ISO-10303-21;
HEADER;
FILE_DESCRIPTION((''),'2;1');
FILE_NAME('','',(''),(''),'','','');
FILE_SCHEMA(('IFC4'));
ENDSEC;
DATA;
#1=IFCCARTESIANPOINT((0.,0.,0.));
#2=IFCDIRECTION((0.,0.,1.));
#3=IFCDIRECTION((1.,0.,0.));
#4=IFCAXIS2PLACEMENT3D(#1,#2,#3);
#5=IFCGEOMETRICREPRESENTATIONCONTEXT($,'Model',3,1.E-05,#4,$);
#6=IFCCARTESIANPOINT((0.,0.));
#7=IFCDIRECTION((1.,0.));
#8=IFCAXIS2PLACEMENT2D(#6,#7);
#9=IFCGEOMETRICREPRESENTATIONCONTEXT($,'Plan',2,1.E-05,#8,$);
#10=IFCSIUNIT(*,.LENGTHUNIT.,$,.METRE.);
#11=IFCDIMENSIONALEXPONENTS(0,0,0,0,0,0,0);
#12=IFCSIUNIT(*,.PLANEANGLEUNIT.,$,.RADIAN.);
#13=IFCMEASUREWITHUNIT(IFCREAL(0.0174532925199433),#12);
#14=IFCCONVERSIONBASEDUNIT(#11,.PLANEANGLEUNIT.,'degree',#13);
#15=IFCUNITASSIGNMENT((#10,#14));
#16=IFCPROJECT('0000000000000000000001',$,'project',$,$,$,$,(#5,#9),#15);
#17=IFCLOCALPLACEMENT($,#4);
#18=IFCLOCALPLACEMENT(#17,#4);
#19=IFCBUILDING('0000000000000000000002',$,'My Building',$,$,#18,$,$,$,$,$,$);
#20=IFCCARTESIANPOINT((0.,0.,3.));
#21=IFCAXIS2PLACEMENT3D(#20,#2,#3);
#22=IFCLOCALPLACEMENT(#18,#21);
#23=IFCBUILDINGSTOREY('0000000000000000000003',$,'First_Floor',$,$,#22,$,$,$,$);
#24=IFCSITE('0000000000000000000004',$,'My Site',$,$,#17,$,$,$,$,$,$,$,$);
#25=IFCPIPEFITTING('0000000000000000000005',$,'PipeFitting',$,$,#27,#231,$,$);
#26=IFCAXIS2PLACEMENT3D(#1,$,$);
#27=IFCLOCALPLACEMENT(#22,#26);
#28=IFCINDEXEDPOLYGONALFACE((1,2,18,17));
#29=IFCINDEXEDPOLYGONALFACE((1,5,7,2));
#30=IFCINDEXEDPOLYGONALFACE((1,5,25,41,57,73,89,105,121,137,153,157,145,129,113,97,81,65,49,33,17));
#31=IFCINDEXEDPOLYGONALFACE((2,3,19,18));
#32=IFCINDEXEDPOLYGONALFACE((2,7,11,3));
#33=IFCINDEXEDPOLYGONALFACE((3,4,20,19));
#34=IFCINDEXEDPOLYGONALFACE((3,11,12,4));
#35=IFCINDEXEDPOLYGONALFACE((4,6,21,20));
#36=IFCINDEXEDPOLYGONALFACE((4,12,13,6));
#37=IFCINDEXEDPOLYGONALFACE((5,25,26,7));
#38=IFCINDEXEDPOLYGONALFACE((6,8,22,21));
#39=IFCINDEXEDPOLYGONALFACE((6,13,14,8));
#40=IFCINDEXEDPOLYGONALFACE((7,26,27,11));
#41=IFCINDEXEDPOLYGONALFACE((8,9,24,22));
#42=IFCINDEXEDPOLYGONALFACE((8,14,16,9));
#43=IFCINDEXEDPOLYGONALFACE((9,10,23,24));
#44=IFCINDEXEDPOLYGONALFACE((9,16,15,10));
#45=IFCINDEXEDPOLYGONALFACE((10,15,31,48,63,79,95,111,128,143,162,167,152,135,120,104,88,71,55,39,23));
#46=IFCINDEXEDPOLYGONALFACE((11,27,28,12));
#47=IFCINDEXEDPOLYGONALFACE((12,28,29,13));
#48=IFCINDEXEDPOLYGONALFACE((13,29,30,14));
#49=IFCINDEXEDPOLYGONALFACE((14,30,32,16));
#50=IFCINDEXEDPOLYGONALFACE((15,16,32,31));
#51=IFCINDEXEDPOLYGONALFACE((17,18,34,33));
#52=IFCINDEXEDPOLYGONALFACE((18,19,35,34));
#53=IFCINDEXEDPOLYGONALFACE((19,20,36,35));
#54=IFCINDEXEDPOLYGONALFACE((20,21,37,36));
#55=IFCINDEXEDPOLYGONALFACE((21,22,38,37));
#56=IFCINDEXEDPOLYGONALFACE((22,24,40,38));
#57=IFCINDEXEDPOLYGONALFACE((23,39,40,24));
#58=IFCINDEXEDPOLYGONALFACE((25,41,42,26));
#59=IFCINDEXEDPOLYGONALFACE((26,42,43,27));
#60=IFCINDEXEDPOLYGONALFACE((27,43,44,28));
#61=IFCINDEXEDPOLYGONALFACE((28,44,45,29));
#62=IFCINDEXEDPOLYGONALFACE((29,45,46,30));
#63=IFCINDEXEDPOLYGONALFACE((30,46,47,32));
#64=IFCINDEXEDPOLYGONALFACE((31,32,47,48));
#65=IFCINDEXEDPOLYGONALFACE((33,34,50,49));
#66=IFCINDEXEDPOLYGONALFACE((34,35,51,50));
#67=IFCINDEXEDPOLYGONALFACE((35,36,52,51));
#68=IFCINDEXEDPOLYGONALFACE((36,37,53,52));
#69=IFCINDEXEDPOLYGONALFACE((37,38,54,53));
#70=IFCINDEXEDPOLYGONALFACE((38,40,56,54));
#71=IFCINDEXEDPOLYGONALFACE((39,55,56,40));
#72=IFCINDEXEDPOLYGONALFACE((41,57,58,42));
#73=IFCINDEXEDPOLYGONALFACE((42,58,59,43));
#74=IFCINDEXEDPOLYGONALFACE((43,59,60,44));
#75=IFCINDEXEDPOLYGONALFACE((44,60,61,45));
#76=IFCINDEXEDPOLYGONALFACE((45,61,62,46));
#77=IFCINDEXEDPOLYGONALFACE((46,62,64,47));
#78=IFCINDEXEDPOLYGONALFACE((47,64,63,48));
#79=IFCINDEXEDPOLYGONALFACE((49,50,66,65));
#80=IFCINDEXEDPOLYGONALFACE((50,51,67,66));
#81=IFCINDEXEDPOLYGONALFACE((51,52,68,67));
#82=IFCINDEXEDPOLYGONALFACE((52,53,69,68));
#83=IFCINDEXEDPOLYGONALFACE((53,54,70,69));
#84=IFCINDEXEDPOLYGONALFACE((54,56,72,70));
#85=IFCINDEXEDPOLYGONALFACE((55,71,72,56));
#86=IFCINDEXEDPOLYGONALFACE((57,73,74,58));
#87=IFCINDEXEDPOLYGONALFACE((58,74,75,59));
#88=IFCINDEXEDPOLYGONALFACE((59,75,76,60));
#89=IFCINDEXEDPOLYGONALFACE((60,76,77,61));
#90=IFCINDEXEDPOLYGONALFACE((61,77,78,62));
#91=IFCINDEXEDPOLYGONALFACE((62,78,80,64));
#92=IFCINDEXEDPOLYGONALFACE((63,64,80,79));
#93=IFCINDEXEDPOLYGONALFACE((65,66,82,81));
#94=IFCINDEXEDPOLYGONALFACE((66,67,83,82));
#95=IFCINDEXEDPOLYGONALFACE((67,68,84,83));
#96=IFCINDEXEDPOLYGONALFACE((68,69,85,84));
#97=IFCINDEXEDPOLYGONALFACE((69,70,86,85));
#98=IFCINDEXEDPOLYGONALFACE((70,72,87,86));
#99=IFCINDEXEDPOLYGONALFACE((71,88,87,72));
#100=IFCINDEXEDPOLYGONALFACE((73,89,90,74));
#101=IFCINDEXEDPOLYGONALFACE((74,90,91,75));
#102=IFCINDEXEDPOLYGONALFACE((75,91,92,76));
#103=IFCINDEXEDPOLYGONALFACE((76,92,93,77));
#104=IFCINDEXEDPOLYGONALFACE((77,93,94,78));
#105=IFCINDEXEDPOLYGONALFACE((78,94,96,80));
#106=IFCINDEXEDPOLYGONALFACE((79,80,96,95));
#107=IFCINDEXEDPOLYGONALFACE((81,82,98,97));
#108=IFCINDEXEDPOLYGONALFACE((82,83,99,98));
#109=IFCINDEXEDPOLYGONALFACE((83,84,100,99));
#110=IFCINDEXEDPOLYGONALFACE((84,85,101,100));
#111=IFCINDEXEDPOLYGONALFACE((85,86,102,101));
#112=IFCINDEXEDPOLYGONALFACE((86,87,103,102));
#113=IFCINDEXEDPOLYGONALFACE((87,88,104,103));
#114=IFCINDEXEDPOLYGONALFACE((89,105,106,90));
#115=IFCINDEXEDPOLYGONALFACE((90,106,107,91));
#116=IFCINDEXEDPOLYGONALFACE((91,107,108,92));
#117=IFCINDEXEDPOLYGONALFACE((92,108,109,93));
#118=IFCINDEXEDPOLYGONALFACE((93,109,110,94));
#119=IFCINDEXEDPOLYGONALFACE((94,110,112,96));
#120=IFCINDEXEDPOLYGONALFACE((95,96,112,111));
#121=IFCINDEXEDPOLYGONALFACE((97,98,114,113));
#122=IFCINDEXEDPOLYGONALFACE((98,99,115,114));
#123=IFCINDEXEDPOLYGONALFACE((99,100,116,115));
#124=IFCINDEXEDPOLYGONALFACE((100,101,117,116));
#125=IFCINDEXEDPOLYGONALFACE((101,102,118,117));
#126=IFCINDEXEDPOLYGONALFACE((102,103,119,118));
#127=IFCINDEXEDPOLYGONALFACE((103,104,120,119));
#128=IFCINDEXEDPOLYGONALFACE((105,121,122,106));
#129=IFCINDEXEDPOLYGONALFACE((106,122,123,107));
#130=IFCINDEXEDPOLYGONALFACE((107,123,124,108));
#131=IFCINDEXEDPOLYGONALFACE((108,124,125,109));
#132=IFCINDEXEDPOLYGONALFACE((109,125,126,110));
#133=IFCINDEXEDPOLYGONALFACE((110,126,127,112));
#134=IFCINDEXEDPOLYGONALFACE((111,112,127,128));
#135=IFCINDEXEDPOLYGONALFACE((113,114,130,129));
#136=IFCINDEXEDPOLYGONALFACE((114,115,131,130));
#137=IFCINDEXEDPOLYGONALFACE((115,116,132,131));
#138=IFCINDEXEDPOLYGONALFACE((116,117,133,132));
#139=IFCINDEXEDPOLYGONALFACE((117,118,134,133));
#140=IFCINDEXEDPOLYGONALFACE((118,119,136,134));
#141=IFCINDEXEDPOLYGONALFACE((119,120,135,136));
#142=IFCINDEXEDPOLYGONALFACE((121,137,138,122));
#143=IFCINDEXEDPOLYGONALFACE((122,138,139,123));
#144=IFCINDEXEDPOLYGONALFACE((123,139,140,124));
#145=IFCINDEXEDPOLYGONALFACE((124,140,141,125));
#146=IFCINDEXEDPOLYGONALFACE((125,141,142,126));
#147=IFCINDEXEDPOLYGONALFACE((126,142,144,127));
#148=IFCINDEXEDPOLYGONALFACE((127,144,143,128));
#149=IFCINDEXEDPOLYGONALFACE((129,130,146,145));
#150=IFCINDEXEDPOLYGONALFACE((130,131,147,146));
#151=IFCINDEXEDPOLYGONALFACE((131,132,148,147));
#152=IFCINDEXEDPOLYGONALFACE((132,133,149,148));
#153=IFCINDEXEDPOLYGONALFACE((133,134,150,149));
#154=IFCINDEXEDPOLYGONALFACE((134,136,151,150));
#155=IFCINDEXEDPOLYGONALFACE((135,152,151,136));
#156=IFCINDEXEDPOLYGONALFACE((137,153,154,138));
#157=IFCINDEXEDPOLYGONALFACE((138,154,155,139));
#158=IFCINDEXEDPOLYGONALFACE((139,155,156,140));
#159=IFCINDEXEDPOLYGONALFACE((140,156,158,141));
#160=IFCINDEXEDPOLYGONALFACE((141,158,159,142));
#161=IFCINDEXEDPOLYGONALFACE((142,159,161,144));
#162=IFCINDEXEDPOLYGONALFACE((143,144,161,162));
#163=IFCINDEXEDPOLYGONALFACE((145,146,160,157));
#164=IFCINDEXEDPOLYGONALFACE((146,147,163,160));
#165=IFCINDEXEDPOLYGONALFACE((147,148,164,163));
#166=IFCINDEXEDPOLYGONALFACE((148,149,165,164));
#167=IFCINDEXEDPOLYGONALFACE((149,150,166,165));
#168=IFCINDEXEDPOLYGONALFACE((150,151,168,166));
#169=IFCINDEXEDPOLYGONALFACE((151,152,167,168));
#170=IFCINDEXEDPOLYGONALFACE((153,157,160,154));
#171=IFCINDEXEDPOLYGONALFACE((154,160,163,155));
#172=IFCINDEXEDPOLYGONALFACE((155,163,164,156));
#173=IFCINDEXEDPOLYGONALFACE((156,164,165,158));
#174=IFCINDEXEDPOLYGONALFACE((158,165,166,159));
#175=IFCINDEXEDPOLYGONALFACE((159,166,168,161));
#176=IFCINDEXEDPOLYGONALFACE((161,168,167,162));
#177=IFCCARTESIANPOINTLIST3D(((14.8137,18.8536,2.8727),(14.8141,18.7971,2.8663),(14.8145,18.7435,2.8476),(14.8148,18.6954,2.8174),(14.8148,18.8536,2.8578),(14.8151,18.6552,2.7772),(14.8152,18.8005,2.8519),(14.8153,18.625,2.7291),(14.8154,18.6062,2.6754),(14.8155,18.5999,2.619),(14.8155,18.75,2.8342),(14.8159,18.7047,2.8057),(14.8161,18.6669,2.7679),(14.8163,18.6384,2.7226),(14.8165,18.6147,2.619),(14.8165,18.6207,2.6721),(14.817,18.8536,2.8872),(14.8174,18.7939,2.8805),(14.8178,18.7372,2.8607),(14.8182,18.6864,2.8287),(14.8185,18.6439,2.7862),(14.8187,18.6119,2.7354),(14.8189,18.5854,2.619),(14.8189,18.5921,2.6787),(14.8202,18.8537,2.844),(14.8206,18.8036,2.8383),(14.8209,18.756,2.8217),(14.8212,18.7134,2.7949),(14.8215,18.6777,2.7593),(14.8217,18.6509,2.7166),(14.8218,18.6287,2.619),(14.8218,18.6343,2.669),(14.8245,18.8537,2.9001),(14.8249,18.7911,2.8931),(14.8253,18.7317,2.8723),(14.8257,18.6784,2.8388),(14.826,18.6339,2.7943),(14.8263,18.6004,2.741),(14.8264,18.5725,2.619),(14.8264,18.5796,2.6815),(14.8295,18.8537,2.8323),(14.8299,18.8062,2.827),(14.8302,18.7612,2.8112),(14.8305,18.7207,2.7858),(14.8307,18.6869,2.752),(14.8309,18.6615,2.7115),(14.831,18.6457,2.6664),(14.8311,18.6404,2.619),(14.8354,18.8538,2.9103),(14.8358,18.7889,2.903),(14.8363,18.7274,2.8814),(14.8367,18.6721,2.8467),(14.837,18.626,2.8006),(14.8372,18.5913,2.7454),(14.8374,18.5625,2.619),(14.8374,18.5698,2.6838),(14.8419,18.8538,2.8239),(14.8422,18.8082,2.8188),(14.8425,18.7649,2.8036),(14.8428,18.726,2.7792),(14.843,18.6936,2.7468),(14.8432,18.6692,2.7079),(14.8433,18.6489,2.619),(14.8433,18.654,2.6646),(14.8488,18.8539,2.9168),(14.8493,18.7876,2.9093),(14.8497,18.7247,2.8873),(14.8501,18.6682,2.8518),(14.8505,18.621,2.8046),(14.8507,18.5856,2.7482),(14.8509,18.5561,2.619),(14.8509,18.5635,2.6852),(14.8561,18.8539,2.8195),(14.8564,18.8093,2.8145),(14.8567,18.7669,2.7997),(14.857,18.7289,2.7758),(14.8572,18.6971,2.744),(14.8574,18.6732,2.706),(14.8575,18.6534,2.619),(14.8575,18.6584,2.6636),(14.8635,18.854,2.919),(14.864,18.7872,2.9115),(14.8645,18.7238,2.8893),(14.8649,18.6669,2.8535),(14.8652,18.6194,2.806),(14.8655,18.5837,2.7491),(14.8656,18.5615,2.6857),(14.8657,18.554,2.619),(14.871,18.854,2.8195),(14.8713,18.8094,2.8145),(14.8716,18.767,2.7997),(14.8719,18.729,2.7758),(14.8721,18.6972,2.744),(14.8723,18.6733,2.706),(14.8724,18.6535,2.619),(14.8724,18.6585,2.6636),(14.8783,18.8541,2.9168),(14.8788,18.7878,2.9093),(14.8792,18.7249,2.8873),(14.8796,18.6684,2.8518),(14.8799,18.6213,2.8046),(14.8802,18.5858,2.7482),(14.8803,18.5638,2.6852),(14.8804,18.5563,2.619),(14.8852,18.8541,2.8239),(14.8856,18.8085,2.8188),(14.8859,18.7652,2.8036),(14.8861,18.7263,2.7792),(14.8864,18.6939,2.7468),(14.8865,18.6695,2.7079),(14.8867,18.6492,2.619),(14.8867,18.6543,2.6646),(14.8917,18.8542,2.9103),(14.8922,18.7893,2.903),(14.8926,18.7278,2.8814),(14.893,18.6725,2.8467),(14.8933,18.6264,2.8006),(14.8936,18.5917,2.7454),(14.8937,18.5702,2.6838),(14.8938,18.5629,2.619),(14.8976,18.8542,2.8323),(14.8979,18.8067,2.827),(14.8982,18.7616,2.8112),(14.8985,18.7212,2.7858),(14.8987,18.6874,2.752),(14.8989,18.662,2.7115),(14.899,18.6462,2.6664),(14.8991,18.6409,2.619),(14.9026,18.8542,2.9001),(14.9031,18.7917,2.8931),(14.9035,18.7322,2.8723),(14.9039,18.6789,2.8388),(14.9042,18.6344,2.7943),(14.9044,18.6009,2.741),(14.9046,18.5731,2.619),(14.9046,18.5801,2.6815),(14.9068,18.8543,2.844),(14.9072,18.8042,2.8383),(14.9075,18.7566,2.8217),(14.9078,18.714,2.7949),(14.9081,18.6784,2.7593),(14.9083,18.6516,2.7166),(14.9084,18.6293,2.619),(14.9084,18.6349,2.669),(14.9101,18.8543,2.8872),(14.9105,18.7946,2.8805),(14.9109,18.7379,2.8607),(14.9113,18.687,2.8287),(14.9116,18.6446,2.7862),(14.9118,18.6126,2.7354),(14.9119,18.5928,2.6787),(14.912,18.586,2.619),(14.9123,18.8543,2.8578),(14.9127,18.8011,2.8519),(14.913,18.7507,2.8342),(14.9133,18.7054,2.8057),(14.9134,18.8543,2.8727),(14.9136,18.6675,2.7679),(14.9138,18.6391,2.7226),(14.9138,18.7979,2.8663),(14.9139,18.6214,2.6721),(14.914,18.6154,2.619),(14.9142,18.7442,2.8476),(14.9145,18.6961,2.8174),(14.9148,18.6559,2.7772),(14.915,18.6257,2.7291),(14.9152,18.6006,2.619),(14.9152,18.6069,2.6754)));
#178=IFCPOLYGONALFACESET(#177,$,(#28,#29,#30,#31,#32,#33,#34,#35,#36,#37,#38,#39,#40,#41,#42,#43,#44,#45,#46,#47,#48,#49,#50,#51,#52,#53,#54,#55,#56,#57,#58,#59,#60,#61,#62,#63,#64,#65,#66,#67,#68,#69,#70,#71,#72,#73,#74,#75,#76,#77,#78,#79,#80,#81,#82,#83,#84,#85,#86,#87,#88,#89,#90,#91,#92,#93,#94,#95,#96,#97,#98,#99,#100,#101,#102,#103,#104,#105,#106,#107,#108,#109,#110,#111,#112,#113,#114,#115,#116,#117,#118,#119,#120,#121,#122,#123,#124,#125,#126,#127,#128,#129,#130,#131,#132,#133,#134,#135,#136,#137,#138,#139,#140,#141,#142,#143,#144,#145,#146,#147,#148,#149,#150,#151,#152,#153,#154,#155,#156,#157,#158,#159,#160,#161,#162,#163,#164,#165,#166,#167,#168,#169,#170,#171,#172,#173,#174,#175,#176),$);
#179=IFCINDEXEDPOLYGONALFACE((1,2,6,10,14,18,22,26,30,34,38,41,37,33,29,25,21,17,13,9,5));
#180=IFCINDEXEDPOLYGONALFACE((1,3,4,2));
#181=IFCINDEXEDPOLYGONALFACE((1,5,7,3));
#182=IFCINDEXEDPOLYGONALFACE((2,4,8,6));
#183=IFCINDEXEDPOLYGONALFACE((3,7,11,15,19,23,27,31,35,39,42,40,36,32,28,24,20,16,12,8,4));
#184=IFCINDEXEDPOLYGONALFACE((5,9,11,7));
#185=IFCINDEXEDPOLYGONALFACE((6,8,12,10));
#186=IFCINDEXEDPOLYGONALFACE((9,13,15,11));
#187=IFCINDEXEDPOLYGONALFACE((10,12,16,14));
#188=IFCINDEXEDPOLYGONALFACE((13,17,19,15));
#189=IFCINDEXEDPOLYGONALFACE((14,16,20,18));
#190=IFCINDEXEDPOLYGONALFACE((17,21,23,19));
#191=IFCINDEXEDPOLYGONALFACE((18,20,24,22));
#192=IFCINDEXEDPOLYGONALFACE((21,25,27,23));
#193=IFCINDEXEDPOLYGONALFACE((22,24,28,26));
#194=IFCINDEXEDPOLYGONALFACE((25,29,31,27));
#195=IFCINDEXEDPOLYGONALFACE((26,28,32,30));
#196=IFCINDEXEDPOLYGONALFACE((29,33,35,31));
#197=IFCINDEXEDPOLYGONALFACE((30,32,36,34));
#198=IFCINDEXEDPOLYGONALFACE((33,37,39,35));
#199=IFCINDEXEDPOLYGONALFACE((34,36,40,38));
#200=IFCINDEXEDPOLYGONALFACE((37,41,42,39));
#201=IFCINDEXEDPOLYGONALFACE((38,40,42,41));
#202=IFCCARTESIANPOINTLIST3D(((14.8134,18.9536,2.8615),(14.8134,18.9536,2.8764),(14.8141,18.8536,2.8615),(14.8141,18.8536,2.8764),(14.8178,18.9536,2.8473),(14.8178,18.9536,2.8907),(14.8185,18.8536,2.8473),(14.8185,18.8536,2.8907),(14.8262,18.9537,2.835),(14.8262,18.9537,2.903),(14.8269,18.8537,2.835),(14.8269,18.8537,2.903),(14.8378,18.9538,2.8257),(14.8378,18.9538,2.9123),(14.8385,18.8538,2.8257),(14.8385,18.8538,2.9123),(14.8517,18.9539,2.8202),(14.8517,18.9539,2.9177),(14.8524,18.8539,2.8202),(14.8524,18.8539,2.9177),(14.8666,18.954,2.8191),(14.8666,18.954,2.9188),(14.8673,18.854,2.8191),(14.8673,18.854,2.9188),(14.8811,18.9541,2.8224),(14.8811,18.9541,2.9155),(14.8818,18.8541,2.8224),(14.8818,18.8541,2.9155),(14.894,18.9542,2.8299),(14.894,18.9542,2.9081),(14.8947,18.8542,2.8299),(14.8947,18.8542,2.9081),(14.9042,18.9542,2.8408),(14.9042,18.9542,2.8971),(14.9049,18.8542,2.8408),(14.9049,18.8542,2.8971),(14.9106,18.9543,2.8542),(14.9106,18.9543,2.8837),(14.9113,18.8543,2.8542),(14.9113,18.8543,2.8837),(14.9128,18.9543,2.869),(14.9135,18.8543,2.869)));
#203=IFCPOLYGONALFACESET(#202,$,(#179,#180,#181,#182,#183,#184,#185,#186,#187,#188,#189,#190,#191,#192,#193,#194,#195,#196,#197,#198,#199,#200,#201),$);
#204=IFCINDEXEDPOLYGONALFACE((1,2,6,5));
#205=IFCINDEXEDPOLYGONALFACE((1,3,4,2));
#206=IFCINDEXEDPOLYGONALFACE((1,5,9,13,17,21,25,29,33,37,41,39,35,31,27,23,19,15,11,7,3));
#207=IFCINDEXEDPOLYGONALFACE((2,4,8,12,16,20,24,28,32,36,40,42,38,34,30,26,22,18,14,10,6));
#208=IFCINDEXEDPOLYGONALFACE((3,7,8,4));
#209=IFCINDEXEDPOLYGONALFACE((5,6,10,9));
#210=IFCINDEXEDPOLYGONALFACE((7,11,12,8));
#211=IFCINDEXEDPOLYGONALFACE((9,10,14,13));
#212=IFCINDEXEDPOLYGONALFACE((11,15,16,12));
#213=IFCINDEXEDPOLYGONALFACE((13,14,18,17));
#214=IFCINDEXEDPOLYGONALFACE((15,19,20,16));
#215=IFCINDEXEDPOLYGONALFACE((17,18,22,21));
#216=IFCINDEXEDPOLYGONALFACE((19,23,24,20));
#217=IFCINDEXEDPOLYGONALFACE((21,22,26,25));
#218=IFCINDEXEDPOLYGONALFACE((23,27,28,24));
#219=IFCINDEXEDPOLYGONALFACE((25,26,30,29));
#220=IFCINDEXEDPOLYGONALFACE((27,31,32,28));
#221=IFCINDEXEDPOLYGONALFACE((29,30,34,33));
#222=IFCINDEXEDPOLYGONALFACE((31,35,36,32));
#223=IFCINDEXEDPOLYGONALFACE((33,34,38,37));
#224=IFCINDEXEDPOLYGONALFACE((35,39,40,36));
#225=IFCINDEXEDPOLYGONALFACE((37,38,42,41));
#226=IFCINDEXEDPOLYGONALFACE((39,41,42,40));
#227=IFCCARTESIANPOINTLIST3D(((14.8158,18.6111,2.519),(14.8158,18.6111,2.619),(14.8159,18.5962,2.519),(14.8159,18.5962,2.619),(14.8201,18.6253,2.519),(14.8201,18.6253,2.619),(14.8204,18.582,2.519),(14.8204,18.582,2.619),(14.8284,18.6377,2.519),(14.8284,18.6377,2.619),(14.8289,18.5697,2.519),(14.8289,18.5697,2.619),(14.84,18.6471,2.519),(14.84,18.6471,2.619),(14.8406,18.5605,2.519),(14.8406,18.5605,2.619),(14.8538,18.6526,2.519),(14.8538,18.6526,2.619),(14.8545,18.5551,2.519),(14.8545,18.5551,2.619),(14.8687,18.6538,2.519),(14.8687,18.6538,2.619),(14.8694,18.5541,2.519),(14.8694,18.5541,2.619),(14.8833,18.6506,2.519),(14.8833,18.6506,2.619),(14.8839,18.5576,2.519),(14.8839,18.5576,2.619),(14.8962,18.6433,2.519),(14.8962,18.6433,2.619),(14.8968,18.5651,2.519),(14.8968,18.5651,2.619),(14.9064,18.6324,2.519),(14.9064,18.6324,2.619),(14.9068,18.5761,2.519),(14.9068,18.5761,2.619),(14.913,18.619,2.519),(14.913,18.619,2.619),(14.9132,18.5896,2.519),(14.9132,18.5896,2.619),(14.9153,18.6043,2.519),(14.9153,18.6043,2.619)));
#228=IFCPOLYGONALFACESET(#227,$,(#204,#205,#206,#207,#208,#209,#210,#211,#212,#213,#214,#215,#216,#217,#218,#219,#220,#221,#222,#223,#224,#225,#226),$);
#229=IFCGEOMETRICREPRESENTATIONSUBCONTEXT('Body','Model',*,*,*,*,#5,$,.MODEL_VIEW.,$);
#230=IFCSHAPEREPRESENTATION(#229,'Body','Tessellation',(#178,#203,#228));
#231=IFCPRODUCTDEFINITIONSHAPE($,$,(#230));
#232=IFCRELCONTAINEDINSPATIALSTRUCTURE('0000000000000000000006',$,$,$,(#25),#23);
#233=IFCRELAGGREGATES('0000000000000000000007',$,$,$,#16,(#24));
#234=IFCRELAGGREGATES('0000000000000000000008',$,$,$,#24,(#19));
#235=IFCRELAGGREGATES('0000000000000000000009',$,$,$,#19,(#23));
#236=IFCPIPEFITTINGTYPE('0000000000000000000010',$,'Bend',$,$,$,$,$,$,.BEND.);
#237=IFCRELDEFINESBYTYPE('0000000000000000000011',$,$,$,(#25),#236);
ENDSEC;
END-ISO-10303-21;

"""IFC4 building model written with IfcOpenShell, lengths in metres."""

from ifc_helpers import new_model, entity, si_unit, converted_unit, frame, origin_with_axes, origin_2d_with_axis, place, context, subcontext, project, spatial, circle, extrude, source, transform, mapped, type_object, type_shapes, element, save


model = new_model("IFC4")

# Units and contexts
model_context = context("Model", 3, precision=1e-05, world=origin_with_axes())
plan_context = context("Plan", 2, precision=1e-05, world=origin_2d_with_axis())
body_context_1 = subcontext(model_context, "Body", "Model", "MODEL_VIEW")
ifc_project = project(units=[si_unit("LENGTHUNIT", "METRE"), converted_unit("PLANEANGLEUNIT", "degree", entity("IfcReal", 0.0174532925199433), si_unit("PLANEANGLEUNIT", "RADIAN"), dimensions=[0, 0, 0, 0, 0, 0, 0])], contexts=[model_context, plan_context])

# Site, building, storey
site_placement = place(None, origin_with_axes())
site = spatial("IfcSite", under=ifc_project, at=site_placement, Name="My Site")
building_placement = place(site_placement, origin_with_axes())
building = spatial("IfcBuilding", under=site, at=building_placement, Name="My Building")
storey_placement = place(building_placement, frame((0.0, 0.0, 3.0), z_axis=(0.0, 0.0, 1.0), x_axis=(1.0, 0.0, 0.0)))
storey = spatial("IfcBuildingStorey", under=building, at=storey_placement, Name="First_Floor")

# Pipe fitting
pipe_fitting_type = type_object("IfcPipeFittingType", Name="Bend", PredefinedType="BEND")
shared_shape_1 = source(origin_with_axes(), body_context_1, "Body", "SolidModel", [
    entity("IfcSweptDiskSolid", entity("IfcIndexedPolyCurve", entity("IfcCartesianPointList3D", [[0.0, 0.0, -0.1], [0.0, 0.0732, -0.2768], [0.0, 0.25, -0.35]]), [entity("IfcArcIndex", [1, 2, 3])]), 0.05),
    extrude(circle(Radius=0.05), origin_with_axes(), (0.0, 0.0, -1.0), 0.1),
    extrude(circle(Radius=0.05), frame((0.0, 0.25, -0.35), z_axis=(0.0, 1.0, 0.0), x_axis=(1.0, 0.0, 0.0)), (0.0, 0.0, 1.0), 0.1),
])
type_shapes(pipe_fitting_type, [shared_shape_1])
for number, where, z_axis, x_axis, name in (
    (1, (14.8628, 18.954, 2.869), (-0.007084, 0.999975, 0.0), (0.999975, 0.007084, 0.0), "PipeFitting"),
):
    element("IfcPipeFitting", number, at=place(storey_placement, frame(where, z_axis=z_axis, x_axis=x_axis)), inside=storey, type_object=pipe_fitting_type, Name=name, context=body_context_1, shape_type="MappedRepresentation", body=[
        mapped(shared_shape_1, transform((0.0, 0.0, 0.0), x_axis=(1.0, 0.0, 0.0), y_axis=(0.0, 1.0, 0.0), z_axis=(0.0, 0.0, 1.0), scale=1.0)),
    ])

save(model, "model.ifc")
